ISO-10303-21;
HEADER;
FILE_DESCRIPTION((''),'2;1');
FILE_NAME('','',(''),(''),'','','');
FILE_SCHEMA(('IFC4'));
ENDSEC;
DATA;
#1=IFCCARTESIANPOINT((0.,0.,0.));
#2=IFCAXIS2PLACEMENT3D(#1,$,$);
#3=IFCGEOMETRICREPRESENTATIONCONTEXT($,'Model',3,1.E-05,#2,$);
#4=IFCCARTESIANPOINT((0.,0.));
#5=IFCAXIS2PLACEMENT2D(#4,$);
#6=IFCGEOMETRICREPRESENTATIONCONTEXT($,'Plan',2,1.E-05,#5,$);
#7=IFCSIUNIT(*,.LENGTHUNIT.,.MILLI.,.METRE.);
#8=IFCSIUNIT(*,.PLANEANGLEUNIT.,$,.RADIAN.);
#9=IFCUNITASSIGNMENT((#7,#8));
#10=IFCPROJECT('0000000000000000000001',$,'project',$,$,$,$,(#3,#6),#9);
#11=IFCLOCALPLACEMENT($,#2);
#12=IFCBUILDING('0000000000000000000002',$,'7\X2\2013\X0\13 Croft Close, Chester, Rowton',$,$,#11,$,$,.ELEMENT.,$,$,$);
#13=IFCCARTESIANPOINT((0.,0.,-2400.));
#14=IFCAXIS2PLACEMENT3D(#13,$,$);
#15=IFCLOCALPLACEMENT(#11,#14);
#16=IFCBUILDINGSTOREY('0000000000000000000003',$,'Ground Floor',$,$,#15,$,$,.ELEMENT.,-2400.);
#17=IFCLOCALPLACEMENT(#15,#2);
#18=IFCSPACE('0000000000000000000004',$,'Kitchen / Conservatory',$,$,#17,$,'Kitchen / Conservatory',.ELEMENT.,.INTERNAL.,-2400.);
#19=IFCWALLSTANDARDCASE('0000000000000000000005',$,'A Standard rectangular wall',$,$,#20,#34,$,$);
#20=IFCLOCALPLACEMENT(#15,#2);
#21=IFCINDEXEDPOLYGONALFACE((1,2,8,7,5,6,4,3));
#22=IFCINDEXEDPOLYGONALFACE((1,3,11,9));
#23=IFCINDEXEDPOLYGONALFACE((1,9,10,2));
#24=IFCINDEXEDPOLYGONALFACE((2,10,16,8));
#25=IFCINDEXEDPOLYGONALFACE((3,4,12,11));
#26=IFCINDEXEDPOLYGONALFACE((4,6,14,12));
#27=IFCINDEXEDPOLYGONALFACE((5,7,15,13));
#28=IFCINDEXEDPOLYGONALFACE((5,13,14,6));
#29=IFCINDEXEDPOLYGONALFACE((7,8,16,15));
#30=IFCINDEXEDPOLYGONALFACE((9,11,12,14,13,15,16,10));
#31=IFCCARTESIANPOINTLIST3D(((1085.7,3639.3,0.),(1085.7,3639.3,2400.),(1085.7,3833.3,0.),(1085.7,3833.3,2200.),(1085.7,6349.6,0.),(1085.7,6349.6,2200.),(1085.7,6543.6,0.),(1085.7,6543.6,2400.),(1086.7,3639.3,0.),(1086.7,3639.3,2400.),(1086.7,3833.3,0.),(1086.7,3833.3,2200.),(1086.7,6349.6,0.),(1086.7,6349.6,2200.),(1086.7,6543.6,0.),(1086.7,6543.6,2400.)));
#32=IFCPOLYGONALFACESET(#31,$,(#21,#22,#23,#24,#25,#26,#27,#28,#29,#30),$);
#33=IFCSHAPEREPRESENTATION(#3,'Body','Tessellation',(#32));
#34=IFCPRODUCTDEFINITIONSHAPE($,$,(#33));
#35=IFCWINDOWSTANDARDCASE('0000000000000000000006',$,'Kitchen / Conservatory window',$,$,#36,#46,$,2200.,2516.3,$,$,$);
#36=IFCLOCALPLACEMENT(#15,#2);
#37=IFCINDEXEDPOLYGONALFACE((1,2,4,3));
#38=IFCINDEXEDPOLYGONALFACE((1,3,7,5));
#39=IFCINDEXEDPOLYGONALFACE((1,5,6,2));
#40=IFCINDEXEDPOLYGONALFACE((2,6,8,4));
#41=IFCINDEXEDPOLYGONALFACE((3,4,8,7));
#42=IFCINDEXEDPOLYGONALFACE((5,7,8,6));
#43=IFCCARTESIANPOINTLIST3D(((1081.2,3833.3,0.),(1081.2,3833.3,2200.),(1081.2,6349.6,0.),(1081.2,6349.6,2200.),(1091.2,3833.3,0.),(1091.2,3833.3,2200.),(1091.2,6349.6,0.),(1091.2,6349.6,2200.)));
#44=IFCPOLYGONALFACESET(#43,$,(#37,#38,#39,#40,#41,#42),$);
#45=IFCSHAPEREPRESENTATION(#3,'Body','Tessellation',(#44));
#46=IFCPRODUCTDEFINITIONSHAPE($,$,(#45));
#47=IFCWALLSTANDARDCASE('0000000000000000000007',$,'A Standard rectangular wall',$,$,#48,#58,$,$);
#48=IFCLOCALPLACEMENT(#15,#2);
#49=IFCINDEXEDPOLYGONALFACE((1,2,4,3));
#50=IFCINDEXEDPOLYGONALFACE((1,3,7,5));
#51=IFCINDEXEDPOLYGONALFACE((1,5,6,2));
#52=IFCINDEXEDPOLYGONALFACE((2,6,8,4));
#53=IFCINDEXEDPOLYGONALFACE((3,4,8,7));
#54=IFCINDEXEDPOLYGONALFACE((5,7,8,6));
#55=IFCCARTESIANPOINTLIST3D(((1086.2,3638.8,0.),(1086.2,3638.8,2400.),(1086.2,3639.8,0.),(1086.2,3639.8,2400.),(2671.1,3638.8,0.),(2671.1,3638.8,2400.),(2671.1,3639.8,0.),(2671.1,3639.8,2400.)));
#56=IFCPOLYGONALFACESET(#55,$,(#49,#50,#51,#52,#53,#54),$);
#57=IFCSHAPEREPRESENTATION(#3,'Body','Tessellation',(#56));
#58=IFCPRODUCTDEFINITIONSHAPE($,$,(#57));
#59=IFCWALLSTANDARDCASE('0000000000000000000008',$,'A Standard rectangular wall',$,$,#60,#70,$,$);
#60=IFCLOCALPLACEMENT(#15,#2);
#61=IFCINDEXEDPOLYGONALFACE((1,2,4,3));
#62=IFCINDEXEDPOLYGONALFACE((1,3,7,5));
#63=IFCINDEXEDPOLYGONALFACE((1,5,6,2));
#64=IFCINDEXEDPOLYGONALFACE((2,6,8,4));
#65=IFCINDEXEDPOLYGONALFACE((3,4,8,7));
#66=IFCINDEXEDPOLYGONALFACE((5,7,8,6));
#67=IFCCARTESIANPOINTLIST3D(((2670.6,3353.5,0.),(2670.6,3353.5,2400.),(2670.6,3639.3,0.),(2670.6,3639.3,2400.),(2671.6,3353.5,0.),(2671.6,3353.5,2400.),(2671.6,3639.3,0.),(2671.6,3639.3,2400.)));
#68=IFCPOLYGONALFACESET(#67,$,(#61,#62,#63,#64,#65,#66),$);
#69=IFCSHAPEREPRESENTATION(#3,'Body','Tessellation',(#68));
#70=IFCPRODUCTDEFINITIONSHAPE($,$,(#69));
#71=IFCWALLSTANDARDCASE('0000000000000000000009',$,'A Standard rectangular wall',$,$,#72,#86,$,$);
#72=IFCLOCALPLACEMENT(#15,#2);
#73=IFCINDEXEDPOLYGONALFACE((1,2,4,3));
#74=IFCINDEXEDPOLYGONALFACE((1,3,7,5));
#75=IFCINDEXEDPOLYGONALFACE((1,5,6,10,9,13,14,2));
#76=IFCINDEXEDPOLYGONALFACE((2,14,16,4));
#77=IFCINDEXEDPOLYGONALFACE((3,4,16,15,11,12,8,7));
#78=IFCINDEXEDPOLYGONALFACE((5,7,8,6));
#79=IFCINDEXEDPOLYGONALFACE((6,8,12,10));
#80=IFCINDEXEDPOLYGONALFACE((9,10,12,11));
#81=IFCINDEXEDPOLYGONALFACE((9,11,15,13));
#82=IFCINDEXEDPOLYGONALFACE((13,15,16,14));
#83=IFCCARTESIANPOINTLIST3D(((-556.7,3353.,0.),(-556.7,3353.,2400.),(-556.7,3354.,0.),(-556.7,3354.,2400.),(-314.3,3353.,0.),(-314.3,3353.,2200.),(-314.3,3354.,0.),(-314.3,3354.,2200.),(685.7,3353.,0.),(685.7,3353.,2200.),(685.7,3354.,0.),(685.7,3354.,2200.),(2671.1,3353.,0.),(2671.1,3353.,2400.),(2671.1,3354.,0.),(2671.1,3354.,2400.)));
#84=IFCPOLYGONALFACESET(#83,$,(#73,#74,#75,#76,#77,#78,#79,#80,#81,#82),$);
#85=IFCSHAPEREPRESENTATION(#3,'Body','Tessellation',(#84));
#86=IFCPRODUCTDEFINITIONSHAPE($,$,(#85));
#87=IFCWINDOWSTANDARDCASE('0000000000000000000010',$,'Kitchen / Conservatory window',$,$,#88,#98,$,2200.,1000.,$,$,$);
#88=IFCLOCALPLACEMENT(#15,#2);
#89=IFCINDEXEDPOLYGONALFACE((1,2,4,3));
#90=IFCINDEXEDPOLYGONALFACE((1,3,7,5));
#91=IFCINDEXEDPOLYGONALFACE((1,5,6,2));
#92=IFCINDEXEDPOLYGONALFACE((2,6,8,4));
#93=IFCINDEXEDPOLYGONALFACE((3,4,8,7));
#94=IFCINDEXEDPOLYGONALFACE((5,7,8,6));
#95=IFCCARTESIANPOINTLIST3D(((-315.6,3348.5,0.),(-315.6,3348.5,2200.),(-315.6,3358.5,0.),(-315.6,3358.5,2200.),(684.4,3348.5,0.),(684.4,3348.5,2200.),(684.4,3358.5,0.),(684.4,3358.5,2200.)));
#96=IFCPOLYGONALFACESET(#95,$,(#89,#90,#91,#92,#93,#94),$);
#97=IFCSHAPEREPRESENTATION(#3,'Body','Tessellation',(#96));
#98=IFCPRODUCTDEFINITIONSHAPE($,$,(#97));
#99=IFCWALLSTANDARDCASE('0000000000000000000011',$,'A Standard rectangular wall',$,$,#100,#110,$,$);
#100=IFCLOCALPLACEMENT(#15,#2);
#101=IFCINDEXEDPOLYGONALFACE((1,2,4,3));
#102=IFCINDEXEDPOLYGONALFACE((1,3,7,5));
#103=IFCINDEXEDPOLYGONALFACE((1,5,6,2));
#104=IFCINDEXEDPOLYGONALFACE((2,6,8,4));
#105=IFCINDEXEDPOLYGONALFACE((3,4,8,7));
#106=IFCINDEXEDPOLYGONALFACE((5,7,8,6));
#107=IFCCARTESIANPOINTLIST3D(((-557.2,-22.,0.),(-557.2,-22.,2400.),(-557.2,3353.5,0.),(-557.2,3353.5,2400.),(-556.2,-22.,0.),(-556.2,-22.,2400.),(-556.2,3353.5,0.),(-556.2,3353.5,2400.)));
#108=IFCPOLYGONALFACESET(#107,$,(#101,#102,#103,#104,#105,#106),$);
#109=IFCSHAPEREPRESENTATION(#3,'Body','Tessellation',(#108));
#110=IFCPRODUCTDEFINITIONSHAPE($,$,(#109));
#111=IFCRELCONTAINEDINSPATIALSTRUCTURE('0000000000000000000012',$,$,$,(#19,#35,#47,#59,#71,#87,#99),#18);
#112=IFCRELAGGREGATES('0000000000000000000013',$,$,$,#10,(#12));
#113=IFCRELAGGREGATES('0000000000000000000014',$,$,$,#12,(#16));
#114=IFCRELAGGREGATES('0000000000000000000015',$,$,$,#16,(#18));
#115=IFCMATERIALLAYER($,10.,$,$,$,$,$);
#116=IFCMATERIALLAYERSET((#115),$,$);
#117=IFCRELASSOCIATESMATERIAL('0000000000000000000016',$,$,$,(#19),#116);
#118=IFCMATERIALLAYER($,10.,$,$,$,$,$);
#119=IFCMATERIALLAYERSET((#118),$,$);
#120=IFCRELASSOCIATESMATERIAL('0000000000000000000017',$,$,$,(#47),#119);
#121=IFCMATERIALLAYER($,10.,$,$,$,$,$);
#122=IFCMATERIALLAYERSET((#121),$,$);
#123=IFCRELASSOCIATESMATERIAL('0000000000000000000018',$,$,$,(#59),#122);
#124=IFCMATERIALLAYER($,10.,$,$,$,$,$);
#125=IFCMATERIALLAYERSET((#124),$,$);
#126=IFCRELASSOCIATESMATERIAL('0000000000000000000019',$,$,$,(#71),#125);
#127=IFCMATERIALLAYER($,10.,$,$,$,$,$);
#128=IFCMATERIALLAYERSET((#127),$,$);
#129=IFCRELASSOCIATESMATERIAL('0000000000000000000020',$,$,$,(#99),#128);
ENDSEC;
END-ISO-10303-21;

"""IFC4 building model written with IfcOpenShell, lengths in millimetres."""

from ifc_helpers import new_model, si_unit, frame, origin, origin_2d, place, context, project, spatial, rectangle, extrude, layer, layer_set, layer_usage, element, fill, save


model = new_model("IFC4")

# Units and contexts
model_context = context("Model", 3, precision=1e-05, world=origin())
plan_context = context("Plan", 2, precision=1e-05, world=origin_2d())
ifc_project = project(units=[si_unit("LENGTHUNIT", "METRE", prefix="MILLI"), si_unit("PLANEANGLEUNIT", "RADIAN")], contexts=[model_context, plan_context])

# Building, storey, space
building_placement = place(None, origin())
building = spatial("IfcBuilding", under=ifc_project, at=building_placement, Name="7–13 Croft Close, Chester, Rowton", CompositionType="ELEMENT")
storey_placement = place(building_placement, frame((0.0, 0.0, -2400.0)))
storey = spatial("IfcBuildingStorey", under=building, at=storey_placement, Name="Ground Floor", CompositionType="ELEMENT", Elevation=-2400.0)
space_placement = place(storey_placement, origin())
space = spatial("IfcSpace", under=storey, at=space_placement, Name="Kitchen / Conservatory", LongName="Kitchen / Conservatory", CompositionType="ELEMENT", PredefinedType="INTERNAL", ElevationWithFlooring=-2400.0)

# Wall, opening, window
ifc_layer_1 = layer(None, 10.0)
ifc_layer_set_1 = layer_set([ifc_layer_1])
ifc_layer_usage_1 = layer_usage(ifc_layer_set_1, "AXIS2", "NEGATIVE", 150.0)
wall_1_placement = place(storey_placement, origin())
wall_1 = element("IfcWallStandardCase", 1, at=wall_1_placement, inside=space, material=ifc_layer_usage_1, Name="A Standard rectangular wall", context=model_context, shape_type="SweptSolid", body=[
    extrude(rectangle(XDim=1.0, YDim=2904.3, at=origin_2d()), frame((1086.2, 5091.5, 0.0), x_axis=(1.0, 0.0, 0.0)), (0.0, 0.0, 1.0), 2400.0),
])
opening_1_placement = place(storey_placement, origin())
opening_1 = element("IfcOpeningElement", 2, at=opening_1_placement, cuts=wall_1, context=model_context, shape_type="SweptSolid", body=[
    extrude(rectangle(XDim=10.0, YDim=2516.3, at=origin_2d()), frame((1086.2, 5091.5, 0.0), x_axis=(1.0, 0.0, 0.0)), (0.0, 0.0, 1.0), 2200.0),
])
window_1_placement = place(storey_placement, frame((0.0, 0.0, 0.0)))
window_1 = element("IfcWindowStandardCase", 3, at=window_1_placement, inside=space, Name="Kitchen / Conservatory window", OverallHeight=2200.0, OverallWidth=2516.3, context=model_context, shape_type="SweptSolid", body=[
    extrude(rectangle(XDim=10.0, YDim=2516.3, at=origin_2d()), frame((1086.2, 5091.5, 0.0), x_axis=(1.0, 0.0, 0.0)), (0.0, 0.0, 1.0), 2200.0),
])
fill(opening_1, window_1)

# Walls
ifc_layer_2 = layer(None, 10.0)
ifc_layer_set_2 = layer_set([ifc_layer_2])
ifc_layer_usage_2 = layer_usage(ifc_layer_set_2, "AXIS2", "NEGATIVE", 150.0)
wall_2_placement = place(storey_placement, origin())
element("IfcWallStandardCase", 4, at=wall_2_placement, inside=space, material=ifc_layer_usage_2, Name="A Standard rectangular wall", context=model_context, shape_type="SweptSolid", body=[
    extrude(rectangle(XDim=1.0, YDim=1584.9, at=origin_2d()), frame((1878.6, 3639.3, 0.0), x_axis=(0.0, 1.0, 0.0)), (0.0, 0.0, 1.0), 2400.0),
])
ifc_layer_3 = layer(None, 10.0)
ifc_layer_set_3 = layer_set([ifc_layer_3])
ifc_layer_usage_3 = layer_usage(ifc_layer_set_3, "AXIS2", "NEGATIVE", 150.0)
wall_3_placement = place(storey_placement, origin())
element("IfcWallStandardCase", 5, at=wall_3_placement, inside=space, material=ifc_layer_usage_3, Name="A Standard rectangular wall", context=model_context, shape_type="SweptSolid", body=[
    extrude(rectangle(XDim=1.0, YDim=285.8, at=origin_2d()), frame((2671.1, 3496.4, 0.0), x_axis=(1.0, 0.0, 0.0)), (0.0, 0.0, 1.0), 2400.0),
])

# Wall, opening, window
ifc_layer_4 = layer(None, 10.0)
ifc_layer_set_4 = layer_set([ifc_layer_4])
ifc_layer_usage_4 = layer_usage(ifc_layer_set_4, "AXIS2", "NEGATIVE", 150.0)
wall_4_placement = place(storey_placement, origin())
wall_4 = element("IfcWallStandardCase", 6, at=wall_4_placement, inside=space, material=ifc_layer_usage_4, Name="A Standard rectangular wall", context=model_context, shape_type="SweptSolid", body=[
    extrude(rectangle(XDim=1.0, YDim=3227.8, at=origin_2d()), frame((1057.2, 3353.5, 0.0), x_axis=(0.0, -1.0, 0.0)), (0.0, 0.0, 1.0), 2400.0),
])
opening_2_placement = place(storey_placement, origin())
opening_2 = element("IfcOpeningElement", 7, at=opening_2_placement, cuts=wall_4, context=model_context, shape_type="SweptSolid", body=[
    extrude(rectangle(XDim=10.0, YDim=1000.0, at=origin_2d()), frame((185.7, 3353.5, 0.0), x_axis=(0.0, -1.0, 0.0)), (0.0, 0.0, 1.0), 2200.0),
])
window_2_placement = place(storey_placement, frame((-1.3, 0.0, 0.0)))
window_2 = element("IfcWindowStandardCase", 8, at=window_2_placement, inside=space, Name="Kitchen / Conservatory window", OverallHeight=2200.0, OverallWidth=1000.0, context=model_context, shape_type="SweptSolid", body=[
    extrude(rectangle(XDim=10.0, YDim=1000.0, at=origin_2d()), frame((185.7, 3353.5, 0.0), x_axis=(0.0, -1.0, 0.0)), (0.0, 0.0, 1.0), 2200.0),
])
fill(opening_2, window_2)

# Wall
ifc_layer_5 = layer(None, 10.0)
ifc_layer_set_5 = layer_set([ifc_layer_5])
ifc_layer_usage_5 = layer_usage(ifc_layer_set_5, "AXIS2", "NEGATIVE", 150.0)
wall_5_placement = place(storey_placement, origin())
element("IfcWallStandardCase", 9, at=wall_5_placement, inside=space, material=ifc_layer_usage_5, Name="A Standard rectangular wall", context=model_context, shape_type="SweptSolid", body=[
    extrude(rectangle(XDim=1.0, YDim=3375.5, at=origin_2d()), frame((-556.7, 1665.8, 0.0), x_axis=(1.0, 0.0, 0.0)), (0.0, 0.0, 1.0), 2400.0),
])

save(model, "model.ifc")
